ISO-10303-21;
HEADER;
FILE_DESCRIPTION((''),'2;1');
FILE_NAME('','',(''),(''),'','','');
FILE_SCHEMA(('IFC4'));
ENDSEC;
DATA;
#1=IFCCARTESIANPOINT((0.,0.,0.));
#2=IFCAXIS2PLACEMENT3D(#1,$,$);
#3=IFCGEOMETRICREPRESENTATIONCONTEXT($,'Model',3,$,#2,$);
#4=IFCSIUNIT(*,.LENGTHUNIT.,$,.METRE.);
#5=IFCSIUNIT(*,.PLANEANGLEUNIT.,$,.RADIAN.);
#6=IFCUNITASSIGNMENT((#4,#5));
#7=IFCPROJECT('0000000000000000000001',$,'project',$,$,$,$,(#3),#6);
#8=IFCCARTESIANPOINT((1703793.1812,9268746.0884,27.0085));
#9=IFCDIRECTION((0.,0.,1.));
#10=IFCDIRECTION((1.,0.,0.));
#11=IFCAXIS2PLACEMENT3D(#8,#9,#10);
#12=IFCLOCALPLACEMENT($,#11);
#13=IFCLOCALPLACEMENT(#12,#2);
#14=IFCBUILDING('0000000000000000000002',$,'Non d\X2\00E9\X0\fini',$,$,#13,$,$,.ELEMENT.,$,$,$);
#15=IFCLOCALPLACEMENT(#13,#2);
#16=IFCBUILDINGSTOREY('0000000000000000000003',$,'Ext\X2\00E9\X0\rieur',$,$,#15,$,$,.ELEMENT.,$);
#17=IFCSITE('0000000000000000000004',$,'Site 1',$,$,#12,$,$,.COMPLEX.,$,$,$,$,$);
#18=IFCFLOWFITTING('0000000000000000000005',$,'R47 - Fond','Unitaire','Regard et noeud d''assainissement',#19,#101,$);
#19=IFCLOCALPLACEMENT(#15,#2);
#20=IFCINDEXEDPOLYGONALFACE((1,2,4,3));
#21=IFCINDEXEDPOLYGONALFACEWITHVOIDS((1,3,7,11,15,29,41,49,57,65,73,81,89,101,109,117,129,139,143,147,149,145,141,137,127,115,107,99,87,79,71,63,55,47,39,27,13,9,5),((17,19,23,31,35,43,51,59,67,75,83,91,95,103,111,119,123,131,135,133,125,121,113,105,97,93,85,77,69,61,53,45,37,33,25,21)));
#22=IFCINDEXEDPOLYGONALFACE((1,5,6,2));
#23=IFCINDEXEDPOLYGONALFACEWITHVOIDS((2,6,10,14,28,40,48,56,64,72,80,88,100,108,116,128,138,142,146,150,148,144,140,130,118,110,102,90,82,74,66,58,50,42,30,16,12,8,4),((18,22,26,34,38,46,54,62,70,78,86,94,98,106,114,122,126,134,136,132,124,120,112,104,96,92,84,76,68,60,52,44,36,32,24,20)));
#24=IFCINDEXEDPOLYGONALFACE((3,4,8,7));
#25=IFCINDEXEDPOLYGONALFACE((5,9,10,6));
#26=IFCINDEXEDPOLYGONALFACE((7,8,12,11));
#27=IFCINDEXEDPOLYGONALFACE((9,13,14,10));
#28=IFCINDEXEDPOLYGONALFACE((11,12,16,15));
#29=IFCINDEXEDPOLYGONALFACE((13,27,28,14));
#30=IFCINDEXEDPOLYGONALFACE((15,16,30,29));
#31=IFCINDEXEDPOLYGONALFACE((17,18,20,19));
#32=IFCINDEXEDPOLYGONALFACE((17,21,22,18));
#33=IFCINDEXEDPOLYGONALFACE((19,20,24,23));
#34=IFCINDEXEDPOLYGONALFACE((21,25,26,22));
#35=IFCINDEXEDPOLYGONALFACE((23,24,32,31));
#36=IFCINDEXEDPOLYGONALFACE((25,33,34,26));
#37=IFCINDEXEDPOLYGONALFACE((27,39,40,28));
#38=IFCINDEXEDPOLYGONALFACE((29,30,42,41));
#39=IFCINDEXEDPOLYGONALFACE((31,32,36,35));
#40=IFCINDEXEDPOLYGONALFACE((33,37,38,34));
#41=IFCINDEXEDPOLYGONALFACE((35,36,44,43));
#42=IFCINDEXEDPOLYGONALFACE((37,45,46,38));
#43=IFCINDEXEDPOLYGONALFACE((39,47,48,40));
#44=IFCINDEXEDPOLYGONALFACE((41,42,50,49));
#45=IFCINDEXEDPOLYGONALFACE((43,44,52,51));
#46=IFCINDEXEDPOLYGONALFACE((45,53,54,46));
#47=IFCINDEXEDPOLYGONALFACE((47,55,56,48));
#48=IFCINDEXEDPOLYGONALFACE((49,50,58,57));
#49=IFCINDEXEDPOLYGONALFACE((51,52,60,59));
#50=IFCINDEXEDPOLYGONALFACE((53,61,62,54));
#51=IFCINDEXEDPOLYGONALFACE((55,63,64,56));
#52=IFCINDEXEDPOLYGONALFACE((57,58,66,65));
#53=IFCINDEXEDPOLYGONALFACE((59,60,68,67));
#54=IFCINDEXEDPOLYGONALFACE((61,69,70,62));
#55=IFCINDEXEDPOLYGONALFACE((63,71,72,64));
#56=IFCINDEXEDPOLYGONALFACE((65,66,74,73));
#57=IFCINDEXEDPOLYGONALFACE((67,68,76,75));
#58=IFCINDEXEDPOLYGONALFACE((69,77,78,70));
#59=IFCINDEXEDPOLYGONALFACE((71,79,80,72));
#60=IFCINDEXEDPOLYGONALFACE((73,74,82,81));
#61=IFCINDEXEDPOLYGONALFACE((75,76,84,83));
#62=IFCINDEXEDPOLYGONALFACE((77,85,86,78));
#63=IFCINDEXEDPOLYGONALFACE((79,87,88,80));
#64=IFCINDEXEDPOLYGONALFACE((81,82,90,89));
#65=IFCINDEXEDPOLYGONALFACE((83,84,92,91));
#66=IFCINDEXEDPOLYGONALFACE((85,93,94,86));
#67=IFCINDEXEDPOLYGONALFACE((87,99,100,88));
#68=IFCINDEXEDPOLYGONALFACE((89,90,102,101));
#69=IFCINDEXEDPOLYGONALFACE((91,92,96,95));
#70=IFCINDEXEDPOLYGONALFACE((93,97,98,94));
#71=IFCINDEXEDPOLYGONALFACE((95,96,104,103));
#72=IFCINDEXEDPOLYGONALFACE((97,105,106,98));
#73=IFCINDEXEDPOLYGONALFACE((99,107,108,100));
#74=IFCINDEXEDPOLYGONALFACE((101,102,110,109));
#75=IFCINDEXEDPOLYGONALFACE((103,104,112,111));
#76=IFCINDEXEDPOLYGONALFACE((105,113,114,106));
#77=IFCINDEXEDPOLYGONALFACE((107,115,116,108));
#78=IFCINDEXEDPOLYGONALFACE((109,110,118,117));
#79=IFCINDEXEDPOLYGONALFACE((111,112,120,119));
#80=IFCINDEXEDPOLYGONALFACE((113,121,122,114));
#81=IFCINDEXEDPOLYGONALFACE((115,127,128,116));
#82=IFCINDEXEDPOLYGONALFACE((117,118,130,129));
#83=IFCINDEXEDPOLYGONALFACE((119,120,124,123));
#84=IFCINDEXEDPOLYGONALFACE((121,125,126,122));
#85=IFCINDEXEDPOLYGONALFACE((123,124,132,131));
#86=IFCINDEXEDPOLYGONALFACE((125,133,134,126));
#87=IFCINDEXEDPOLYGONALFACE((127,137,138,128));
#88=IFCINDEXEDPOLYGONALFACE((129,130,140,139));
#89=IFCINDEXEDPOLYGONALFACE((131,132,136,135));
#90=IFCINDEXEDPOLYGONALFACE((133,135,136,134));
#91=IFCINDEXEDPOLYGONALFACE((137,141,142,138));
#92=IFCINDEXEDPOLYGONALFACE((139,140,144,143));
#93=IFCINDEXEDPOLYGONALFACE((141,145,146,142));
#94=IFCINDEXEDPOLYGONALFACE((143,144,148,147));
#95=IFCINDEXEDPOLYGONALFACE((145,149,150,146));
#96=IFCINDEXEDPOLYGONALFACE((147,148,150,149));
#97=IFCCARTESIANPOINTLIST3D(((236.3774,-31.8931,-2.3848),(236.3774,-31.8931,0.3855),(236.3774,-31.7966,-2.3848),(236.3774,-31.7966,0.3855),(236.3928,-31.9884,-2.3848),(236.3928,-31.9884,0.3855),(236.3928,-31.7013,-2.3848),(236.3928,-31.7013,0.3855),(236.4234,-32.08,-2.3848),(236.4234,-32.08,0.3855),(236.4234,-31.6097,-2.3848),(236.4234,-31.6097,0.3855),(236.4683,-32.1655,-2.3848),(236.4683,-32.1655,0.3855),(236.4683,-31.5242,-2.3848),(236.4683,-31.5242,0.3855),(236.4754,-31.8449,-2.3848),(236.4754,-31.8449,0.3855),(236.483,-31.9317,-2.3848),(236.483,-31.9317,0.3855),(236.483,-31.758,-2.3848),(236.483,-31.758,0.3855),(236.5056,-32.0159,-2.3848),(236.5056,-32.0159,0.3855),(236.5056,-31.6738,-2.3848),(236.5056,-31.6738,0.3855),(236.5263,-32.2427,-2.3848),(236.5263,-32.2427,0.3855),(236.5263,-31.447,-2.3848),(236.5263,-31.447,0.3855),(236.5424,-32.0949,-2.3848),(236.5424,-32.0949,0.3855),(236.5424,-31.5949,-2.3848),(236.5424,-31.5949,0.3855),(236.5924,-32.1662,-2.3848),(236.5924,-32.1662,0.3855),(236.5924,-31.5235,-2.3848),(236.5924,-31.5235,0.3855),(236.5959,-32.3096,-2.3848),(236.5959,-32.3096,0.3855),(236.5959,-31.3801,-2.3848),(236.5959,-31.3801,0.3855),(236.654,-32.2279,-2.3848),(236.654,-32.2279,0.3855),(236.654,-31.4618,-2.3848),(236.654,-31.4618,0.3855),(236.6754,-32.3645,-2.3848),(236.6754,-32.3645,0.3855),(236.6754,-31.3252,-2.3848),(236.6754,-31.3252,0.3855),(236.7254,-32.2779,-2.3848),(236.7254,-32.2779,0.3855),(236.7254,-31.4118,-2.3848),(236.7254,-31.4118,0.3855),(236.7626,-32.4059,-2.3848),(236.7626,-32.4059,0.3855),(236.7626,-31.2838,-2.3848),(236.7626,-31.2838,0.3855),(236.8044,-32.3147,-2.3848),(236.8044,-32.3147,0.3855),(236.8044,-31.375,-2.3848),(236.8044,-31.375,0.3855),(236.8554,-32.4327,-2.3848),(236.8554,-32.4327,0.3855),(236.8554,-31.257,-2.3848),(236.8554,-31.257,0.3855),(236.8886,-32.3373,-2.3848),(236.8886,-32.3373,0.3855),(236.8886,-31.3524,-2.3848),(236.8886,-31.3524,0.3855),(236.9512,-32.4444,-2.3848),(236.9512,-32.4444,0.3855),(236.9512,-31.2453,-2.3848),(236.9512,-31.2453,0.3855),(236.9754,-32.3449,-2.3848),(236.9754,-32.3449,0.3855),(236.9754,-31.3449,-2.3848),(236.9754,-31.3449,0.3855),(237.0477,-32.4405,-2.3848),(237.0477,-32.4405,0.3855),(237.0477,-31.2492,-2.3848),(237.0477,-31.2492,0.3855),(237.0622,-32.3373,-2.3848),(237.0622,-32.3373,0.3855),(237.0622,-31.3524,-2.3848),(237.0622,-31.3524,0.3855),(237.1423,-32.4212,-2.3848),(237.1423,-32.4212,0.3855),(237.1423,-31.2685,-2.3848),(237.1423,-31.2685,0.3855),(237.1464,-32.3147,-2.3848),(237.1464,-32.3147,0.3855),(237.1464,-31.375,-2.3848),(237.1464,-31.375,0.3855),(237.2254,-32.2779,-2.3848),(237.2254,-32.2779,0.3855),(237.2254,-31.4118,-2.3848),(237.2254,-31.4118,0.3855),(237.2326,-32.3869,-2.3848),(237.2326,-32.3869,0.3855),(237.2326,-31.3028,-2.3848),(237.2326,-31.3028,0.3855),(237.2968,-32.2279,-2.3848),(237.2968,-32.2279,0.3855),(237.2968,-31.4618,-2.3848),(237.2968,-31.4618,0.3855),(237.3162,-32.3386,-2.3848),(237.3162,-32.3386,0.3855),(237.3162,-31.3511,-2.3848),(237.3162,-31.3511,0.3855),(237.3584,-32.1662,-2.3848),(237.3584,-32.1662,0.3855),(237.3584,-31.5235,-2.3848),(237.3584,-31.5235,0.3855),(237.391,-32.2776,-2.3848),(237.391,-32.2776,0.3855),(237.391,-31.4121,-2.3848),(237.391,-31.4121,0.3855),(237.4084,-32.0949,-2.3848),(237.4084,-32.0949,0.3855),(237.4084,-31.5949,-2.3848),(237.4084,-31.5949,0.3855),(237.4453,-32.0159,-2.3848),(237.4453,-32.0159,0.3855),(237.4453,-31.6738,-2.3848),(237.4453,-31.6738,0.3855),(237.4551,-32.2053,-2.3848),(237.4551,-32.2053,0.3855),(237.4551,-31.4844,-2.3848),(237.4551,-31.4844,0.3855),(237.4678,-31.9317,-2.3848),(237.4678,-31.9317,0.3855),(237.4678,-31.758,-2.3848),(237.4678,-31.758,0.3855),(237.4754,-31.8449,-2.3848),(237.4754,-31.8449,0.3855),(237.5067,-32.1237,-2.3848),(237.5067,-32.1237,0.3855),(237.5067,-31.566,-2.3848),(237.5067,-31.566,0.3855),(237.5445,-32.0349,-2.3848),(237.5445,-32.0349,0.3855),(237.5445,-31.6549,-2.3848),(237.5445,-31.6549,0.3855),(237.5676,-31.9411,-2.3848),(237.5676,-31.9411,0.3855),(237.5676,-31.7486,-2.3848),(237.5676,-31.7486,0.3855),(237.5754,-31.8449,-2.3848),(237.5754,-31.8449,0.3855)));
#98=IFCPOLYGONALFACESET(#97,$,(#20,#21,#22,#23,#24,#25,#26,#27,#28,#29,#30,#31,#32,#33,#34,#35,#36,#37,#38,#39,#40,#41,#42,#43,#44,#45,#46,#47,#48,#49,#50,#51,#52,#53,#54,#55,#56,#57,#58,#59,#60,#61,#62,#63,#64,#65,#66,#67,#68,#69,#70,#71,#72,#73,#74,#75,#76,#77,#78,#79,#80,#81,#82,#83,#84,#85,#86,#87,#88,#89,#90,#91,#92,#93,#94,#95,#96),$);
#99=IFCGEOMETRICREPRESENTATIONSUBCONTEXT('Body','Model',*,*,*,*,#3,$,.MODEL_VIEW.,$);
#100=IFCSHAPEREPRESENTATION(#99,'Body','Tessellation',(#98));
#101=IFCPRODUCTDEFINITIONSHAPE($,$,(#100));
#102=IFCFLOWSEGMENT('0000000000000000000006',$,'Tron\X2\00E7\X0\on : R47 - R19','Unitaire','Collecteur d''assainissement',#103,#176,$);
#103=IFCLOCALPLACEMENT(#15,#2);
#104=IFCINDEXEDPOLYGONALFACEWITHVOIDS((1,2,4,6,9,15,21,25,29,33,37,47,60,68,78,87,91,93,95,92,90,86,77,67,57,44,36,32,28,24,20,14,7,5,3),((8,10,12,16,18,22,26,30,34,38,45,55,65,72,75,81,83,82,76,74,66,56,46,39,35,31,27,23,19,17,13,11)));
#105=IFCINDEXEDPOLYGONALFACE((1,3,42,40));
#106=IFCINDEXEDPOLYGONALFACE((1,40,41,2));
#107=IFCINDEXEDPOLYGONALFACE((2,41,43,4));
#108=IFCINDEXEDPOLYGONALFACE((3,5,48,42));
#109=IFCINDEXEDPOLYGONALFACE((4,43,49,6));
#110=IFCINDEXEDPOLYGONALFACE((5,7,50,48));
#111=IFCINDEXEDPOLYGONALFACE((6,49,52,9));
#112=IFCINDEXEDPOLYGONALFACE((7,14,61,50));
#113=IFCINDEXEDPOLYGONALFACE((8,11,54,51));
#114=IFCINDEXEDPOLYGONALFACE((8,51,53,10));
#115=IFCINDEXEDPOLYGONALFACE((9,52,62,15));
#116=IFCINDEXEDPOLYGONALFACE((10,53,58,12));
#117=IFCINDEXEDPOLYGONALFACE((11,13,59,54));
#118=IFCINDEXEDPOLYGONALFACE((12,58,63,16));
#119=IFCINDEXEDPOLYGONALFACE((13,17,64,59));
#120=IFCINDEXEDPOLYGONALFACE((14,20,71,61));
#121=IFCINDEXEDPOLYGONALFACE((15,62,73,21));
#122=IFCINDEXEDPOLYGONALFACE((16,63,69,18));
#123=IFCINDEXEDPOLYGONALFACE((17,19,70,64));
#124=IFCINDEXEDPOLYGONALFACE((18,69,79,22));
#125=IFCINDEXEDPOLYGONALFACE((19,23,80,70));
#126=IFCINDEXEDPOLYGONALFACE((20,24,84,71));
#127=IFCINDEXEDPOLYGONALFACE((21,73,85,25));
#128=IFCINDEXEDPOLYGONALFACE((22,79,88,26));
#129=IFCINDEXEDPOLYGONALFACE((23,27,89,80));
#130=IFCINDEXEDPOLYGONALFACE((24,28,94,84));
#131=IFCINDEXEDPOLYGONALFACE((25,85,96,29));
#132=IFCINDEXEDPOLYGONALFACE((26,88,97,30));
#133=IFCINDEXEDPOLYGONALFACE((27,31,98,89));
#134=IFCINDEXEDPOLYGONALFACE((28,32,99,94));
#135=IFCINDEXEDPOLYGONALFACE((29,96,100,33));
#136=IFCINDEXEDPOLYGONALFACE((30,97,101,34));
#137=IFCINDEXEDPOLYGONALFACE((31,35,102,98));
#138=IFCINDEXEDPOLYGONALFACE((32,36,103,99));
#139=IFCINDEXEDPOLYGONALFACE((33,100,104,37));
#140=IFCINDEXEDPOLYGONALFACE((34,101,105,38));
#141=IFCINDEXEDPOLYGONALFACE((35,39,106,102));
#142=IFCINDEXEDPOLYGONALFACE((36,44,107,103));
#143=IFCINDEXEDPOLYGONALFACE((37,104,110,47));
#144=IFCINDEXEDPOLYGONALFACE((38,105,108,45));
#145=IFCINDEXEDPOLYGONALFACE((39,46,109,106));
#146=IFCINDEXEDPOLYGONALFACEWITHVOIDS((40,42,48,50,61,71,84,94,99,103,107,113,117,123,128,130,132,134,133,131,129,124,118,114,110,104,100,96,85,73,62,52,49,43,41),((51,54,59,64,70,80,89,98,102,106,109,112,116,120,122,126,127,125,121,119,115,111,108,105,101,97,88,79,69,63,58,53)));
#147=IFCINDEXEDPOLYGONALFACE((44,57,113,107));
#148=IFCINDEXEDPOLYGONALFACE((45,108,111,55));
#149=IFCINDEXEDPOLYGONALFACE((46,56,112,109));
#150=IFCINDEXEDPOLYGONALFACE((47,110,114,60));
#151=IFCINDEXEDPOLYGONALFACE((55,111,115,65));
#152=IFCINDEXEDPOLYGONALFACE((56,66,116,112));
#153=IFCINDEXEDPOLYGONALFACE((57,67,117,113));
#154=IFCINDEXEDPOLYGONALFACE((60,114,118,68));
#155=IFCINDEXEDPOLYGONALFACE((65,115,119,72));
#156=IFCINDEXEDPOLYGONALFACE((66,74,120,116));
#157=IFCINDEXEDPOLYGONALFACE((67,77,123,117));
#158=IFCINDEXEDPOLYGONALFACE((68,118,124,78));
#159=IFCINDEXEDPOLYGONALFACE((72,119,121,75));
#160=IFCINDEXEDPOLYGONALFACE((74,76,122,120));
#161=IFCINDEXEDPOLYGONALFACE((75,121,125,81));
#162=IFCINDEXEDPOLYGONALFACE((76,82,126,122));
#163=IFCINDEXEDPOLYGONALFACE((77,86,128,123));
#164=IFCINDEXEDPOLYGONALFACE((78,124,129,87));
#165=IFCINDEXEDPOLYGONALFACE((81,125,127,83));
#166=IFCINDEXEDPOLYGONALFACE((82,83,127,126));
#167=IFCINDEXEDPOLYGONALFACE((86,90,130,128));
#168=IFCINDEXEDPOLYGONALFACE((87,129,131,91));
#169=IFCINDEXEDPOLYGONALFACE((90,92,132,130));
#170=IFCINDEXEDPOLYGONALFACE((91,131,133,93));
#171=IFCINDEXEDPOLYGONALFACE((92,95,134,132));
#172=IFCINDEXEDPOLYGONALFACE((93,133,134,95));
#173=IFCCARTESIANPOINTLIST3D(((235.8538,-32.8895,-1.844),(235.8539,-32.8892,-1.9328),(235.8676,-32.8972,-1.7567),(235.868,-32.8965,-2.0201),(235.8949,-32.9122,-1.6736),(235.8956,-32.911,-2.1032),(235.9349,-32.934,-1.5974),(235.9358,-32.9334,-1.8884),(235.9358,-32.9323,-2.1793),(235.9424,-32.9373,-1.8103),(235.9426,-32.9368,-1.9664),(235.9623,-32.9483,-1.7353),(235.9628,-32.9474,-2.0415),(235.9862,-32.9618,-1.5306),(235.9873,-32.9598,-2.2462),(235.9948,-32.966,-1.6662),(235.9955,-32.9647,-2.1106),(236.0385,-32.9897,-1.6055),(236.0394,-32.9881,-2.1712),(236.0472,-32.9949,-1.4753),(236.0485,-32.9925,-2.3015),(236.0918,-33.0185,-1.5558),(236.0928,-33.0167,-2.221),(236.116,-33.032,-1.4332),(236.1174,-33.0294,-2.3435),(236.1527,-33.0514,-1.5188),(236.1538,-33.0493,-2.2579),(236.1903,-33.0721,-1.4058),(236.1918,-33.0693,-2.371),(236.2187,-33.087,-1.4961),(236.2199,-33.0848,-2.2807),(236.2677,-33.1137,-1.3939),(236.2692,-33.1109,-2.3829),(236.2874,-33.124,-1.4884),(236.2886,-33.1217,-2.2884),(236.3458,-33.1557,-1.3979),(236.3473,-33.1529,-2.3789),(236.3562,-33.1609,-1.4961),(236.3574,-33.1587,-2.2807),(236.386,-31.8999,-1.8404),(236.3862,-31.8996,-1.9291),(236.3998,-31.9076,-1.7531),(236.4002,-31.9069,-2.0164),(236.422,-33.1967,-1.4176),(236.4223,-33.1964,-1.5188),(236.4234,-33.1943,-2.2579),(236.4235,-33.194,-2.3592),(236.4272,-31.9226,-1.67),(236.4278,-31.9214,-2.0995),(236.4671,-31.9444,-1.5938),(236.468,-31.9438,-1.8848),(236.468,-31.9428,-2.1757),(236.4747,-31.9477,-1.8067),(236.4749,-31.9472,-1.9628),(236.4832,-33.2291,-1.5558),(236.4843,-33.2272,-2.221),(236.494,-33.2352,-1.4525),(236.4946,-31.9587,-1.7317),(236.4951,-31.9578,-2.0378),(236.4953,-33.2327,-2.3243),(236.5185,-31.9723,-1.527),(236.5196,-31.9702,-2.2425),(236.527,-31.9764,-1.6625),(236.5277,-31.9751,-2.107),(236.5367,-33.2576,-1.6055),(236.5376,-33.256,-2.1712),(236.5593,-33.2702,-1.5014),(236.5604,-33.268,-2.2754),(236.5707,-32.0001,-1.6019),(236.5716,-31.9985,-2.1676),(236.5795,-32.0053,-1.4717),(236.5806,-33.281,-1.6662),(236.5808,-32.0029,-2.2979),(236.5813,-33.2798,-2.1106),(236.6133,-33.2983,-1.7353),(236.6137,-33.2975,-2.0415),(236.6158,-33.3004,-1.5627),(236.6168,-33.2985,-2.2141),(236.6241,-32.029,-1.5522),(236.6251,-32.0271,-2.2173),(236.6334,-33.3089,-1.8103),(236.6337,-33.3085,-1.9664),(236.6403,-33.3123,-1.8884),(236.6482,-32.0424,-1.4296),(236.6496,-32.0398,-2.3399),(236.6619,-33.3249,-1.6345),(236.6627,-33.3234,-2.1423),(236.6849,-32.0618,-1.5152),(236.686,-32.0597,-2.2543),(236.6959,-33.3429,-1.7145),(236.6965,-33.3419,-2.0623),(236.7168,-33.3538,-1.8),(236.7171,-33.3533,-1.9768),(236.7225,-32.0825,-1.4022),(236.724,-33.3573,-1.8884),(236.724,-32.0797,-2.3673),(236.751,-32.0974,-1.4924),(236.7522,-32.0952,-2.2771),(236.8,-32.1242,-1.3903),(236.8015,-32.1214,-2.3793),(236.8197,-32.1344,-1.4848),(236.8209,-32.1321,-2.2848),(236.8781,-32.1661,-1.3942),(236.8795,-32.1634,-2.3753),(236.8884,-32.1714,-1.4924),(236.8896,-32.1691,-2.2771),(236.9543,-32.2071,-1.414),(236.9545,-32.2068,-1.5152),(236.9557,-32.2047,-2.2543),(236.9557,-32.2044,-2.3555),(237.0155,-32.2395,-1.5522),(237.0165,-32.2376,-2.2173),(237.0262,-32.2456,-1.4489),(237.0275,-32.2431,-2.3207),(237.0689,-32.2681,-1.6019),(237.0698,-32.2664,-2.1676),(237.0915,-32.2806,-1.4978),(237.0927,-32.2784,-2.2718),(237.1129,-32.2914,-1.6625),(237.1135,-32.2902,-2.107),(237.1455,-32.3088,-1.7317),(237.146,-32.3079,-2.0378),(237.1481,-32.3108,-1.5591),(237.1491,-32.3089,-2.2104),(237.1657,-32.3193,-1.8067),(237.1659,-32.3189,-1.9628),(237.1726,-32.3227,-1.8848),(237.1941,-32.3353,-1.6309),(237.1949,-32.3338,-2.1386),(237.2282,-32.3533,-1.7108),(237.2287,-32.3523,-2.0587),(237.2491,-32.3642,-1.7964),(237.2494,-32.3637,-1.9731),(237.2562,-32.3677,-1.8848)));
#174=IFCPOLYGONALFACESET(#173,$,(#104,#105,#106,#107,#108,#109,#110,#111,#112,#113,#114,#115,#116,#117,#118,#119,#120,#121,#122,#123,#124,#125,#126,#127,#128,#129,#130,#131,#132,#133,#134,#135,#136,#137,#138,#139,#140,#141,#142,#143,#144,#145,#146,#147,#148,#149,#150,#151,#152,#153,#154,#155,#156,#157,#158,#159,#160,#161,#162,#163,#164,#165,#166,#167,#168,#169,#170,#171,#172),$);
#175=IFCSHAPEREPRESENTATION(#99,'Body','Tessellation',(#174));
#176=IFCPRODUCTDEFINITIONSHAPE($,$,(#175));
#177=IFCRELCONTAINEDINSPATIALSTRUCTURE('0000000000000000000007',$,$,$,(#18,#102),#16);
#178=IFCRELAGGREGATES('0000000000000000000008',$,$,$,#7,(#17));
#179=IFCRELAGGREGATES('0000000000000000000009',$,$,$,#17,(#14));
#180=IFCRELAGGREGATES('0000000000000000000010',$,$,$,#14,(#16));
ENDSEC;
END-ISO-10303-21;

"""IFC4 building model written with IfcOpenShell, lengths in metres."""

from ifc_helpers import new_model, si_unit, frame, origin, origin_2d, place, context, subcontext, project, spatial, hollow_circle, extrude, element, save


model = new_model("IFC4")

# Units and contexts
model_context = context("Model", 3, world=origin())
body_context = subcontext(model_context, "Body", "Model", "MODEL_VIEW")
ifc_project = project(units=[si_unit("LENGTHUNIT", "METRE"), si_unit("PLANEANGLEUNIT", "RADIAN")], contexts=[model_context])

# Site, building, storey
site_placement = place(None, frame((1703793.1812, 9268746.0884, 27.0085), z_axis=(0.0, 0.0, 1.0), x_axis=(1.0, 0.0, 0.0)))
site = spatial("IfcSite", under=ifc_project, at=site_placement, Name="Site 1", CompositionType="COMPLEX")
building_placement = place(site_placement, origin())
building = spatial("IfcBuilding", under=site, at=building_placement, Name="Non défini", CompositionType="ELEMENT")
storey_placement = place(building_placement, origin())
storey = spatial("IfcBuildingStorey", under=building, at=storey_placement, Name="Extérieur", CompositionType="ELEMENT")

# Flow fitting
flow_fitting_1_placement = place(storey_placement, origin())
element("IfcFlowFitting", 1, at=flow_fitting_1_placement, inside=storey, Name="R47 - Fond", Description="Unitaire", ObjectType="Regard et noeud d'assainissement", context=body_context, shape_type="SweptSolid", body=[
    extrude(hollow_circle(Radius=0.6, WallThickness=0.1, at=origin_2d()), frame((236.9754, -31.8449, -2.3848), z_axis=(0.0, 0.0, 1.0), x_axis=(1.0, 0.0, 0.0)), (0.0, 0.0, 1.0), 2.7703),
])

# Flow segment
flow_segment_1_placement = place(storey_placement, origin())
element("IfcFlowSegment", 2, at=flow_segment_1_placement, inside=storey, Name="Tronçon : R47 - R19", Description="Unitaire", ObjectType="Collecteur d'assainissement", context=body_context, shape_type="SweptSolid", body=[
    extrude(hollow_circle(Radius=0.495, WallThickness=0.095, at=origin_2d()), frame((236.8203, -32.1333, -1.8848), z_axis=(-0.473674, -0.880695, -0.003223), x_axis=(0.880699, -0.473676, 0.0)), (0.0, 0.0, 1.0), 1.1236),
])

save(model, "model.ifc")
